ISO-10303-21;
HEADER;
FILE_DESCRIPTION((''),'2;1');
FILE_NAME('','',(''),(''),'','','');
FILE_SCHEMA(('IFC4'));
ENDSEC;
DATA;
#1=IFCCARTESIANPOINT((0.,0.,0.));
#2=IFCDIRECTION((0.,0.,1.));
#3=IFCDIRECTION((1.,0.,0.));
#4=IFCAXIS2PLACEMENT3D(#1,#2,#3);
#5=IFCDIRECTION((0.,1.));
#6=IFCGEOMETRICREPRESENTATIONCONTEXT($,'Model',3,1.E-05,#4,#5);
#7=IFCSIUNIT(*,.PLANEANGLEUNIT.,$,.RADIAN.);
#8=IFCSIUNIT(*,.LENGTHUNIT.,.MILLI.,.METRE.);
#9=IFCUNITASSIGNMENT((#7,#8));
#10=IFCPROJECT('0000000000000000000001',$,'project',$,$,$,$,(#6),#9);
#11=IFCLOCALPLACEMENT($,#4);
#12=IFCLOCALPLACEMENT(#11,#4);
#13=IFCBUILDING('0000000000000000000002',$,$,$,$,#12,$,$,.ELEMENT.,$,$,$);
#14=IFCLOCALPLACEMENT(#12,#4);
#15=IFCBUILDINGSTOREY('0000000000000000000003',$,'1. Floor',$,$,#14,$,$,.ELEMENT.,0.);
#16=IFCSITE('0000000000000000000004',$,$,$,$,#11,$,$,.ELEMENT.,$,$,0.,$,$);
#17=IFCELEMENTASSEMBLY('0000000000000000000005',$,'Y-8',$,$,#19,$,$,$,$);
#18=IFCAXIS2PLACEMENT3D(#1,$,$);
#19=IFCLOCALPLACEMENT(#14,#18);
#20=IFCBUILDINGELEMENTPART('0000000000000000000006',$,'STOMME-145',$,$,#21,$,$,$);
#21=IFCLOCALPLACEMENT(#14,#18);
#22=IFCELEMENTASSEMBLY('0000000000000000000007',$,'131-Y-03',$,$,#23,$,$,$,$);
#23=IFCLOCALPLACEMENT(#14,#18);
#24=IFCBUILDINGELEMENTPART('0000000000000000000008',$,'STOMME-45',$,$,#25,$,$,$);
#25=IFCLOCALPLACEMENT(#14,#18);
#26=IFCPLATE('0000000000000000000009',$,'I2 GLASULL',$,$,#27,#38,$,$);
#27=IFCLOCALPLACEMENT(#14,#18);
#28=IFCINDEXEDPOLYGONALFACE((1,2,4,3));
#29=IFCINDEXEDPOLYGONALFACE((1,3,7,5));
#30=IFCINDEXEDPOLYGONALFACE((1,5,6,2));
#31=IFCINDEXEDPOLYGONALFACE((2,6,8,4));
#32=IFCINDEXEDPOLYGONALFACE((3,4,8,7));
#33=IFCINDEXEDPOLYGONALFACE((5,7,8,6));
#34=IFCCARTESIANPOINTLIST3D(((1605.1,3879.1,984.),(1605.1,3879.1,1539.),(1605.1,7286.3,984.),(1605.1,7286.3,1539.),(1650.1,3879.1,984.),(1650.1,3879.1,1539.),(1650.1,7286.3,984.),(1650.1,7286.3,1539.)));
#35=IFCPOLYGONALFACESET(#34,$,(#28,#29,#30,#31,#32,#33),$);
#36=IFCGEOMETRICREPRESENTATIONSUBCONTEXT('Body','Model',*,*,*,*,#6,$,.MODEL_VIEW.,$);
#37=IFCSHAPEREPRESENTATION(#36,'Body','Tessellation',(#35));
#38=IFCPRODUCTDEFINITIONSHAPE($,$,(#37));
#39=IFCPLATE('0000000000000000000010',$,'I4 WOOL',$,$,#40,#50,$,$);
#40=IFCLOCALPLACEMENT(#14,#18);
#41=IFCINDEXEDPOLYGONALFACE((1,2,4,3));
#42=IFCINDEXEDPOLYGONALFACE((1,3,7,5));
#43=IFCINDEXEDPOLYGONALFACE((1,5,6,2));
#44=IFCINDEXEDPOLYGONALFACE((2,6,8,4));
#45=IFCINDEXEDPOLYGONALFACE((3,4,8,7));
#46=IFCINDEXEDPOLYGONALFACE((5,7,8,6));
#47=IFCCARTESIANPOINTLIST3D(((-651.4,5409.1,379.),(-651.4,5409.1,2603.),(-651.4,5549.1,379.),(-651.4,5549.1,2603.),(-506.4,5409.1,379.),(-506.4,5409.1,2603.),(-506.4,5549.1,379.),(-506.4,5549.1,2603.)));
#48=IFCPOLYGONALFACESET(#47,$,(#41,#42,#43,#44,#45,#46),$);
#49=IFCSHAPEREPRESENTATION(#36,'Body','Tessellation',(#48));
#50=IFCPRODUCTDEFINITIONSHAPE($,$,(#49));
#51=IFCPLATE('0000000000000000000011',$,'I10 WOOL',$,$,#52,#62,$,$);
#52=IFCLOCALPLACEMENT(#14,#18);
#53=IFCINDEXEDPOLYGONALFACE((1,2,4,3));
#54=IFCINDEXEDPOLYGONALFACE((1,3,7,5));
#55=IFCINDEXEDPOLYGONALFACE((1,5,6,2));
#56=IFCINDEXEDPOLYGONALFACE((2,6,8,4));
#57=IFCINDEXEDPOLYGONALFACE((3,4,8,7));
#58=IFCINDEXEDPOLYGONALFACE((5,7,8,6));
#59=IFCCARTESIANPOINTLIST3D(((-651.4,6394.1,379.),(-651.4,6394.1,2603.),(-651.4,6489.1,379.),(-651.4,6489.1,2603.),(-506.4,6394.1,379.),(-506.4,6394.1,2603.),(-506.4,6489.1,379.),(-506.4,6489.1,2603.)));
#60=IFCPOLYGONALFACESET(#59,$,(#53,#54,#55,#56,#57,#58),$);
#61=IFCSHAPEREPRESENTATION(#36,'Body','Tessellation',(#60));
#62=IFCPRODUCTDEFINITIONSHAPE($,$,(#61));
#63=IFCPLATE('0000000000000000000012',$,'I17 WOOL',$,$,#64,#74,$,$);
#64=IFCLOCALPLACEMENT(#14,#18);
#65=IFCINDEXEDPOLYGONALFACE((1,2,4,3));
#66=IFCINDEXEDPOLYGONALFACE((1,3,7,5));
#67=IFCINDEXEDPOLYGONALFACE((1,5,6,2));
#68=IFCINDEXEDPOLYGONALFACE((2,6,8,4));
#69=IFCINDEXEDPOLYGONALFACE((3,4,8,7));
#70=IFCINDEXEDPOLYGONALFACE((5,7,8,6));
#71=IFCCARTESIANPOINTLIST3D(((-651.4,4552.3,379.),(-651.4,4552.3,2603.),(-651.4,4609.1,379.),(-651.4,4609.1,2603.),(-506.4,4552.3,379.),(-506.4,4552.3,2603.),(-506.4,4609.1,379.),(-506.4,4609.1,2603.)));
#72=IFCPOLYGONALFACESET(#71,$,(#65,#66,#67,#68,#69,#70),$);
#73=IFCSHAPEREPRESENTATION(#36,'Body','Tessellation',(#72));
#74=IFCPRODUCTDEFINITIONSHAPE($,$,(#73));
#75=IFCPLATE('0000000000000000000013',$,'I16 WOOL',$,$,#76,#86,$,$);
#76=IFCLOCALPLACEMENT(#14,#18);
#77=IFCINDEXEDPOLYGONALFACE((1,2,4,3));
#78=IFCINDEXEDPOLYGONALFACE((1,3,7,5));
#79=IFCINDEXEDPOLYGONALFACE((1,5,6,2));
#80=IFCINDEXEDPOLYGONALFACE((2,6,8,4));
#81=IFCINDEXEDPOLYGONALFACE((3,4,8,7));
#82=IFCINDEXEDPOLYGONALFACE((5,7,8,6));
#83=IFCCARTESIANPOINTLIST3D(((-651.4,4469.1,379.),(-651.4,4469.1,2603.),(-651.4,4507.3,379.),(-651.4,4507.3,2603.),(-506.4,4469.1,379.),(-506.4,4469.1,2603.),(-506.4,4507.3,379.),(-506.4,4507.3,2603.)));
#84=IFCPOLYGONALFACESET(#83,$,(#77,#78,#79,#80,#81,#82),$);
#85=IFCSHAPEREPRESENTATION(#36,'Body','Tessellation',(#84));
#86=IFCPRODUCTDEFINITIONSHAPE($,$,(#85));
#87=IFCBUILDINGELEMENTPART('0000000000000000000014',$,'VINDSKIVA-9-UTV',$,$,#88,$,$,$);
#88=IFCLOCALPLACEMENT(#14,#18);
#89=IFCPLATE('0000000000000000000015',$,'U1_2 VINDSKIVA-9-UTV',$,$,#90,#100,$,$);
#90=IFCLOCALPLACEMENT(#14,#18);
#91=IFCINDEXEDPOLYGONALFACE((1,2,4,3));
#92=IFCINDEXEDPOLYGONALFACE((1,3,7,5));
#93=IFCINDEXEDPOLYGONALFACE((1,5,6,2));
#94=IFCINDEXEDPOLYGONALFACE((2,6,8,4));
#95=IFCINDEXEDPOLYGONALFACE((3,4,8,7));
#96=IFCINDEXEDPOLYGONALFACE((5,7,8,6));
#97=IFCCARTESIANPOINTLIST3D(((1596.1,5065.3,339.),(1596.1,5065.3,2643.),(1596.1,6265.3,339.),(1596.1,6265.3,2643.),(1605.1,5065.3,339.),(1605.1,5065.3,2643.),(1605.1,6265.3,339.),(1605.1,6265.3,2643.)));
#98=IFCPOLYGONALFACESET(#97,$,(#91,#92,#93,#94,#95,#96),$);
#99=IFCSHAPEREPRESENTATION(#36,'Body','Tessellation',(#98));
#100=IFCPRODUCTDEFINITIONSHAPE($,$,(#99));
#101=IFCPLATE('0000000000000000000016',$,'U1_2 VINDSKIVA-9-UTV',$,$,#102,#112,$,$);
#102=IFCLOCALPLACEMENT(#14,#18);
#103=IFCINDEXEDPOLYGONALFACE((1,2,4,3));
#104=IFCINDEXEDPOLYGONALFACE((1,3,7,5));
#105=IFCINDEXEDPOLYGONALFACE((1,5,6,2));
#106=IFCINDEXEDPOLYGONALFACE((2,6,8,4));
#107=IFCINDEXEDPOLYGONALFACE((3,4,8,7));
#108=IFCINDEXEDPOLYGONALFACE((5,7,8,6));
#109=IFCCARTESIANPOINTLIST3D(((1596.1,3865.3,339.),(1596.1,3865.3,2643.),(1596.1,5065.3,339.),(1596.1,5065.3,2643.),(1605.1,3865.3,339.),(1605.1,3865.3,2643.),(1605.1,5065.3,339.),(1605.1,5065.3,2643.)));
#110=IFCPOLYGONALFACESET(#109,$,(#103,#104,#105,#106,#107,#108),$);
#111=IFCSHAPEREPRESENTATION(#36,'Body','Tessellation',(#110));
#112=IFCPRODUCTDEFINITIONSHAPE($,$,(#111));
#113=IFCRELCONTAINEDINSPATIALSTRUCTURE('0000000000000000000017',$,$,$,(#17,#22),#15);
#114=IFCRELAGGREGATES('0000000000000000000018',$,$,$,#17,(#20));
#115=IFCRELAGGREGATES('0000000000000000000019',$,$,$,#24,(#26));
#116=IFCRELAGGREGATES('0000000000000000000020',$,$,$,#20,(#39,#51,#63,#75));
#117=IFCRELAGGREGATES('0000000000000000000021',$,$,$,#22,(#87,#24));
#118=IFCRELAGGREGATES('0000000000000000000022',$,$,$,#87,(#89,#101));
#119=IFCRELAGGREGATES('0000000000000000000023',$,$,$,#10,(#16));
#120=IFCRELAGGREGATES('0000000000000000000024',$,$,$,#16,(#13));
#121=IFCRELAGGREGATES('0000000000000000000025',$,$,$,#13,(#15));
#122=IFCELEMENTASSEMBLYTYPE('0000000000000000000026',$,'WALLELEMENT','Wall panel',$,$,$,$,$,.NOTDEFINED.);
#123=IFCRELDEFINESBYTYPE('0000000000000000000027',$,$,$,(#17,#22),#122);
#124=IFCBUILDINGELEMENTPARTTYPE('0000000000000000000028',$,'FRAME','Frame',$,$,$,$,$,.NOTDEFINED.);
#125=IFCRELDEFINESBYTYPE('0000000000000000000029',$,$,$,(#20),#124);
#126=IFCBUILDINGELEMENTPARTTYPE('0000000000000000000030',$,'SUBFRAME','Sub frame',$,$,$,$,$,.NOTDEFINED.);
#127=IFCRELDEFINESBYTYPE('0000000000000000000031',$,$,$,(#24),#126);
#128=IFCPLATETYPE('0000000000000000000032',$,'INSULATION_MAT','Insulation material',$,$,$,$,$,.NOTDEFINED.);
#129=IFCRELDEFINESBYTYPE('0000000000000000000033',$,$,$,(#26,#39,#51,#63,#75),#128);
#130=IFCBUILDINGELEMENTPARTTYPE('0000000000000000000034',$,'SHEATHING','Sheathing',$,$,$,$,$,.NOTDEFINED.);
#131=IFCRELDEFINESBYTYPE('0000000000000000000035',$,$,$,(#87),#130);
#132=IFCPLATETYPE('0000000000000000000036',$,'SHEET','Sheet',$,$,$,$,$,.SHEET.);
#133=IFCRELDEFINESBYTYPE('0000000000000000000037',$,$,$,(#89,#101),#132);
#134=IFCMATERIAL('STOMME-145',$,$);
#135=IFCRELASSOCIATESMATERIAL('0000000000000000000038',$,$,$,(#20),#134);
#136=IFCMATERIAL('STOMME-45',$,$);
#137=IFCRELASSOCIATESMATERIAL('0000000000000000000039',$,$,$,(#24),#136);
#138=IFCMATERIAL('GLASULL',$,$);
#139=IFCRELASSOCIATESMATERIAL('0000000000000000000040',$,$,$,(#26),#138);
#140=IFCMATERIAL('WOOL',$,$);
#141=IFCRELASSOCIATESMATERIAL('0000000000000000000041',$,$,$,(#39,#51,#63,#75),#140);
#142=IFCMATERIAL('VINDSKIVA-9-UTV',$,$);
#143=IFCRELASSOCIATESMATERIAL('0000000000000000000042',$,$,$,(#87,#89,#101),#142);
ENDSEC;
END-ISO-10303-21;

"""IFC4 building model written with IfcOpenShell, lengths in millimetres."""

from ifc_helpers import new_model, si_unit, direction, frame, origin_with_axes, origin_2d_with_axis, place, context, subcontext, project, spatial, rectangle, extrude, material, type_object, element, aggregate, save


model = new_model("IFC4")

# Units and contexts
model_context = context("Model", 3, precision=1e-05, world=origin_with_axes(), true_north=direction((0.0, 1.0)))
body_context = subcontext(model_context, "Body", "Model", "MODEL_VIEW")
ifc_project = project(units=[si_unit("PLANEANGLEUNIT", "RADIAN"), si_unit("LENGTHUNIT", "METRE", prefix="MILLI")], contexts=[model_context])

# Site, building, storey
site_placement = place(None, origin_with_axes())
site = spatial("IfcSite", under=ifc_project, at=site_placement, CompositionType="ELEMENT", RefElevation=0.0)
building_placement = place(site_placement, origin_with_axes())
building = spatial("IfcBuilding", under=site, at=building_placement, CompositionType="ELEMENT")
storey_placement = place(building_placement, origin_with_axes())
storey = spatial("IfcBuildingStorey", under=building, at=storey_placement, Name="1. Floor", CompositionType="ELEMENT", Elevation=0.0)

# Element assembly, building element part
element_assembly_type = type_object("IfcElementAssemblyType", Name="WALLELEMENT", Description="Wall panel", PredefinedType="NOTDEFINED")
assembly_1_placement = place(storey_placement, origin_with_axes())
assembly_1 = element("IfcElementAssembly", 1, at=assembly_1_placement, inside=storey, type_object=element_assembly_type, Name="Y-8")
ifc_material_1 = material(Name="STOMME-145")
building_element_part_type_1 = type_object("IfcBuildingElementPartType", Name="FRAME", Description="Frame", PredefinedType="NOTDEFINED")
building_element_part_1_placement = place(storey_placement, origin_with_axes())
building_element_part_1 = element("IfcBuildingElementPart", 2, at=building_element_part_1_placement, type_object=building_element_part_type_1, material=ifc_material_1, Name="STOMME-145")

# Element assembly, building element part
assembly_2_placement = place(storey_placement, origin_with_axes())
assembly_2 = element("IfcElementAssembly", 3, at=assembly_2_placement, inside=storey, type_object=element_assembly_type, Name="131-Y-03")
ifc_material_2 = material(Name="STOMME-45")
building_element_part_type_2 = type_object("IfcBuildingElementPartType", Name="SUBFRAME", Description="Sub frame", PredefinedType="NOTDEFINED")
building_element_part_2_placement = place(storey_placement, origin_with_axes())
building_element_part_2 = element("IfcBuildingElementPart", 4, at=building_element_part_2_placement, type_object=building_element_part_type_2, material=ifc_material_2, Name="STOMME-45")

aggregate(assembly_1, [building_element_part_1])

# Plates
ifc_material_3 = material(Name="GLASULL")
plate_type_1 = type_object("IfcPlateType", Name="INSULATION_MAT", Description="Insulation material", PredefinedType="NOTDEFINED")
plate_1_placement = place(storey_placement, frame((1605.1, 5582.7, 1261.5), z_axis=(-1.0, 0.0, 0.0), x_axis=(0.0, -1.0, 0.0)))
plate_1 = element("IfcPlate", 5, at=plate_1_placement, type_object=plate_type_1, material=ifc_material_3, Name="I2 GLASULL", context=body_context, shape_type="SweptSolid", body=[
    extrude(rectangle(XDim=45.0, YDim=3407.2, at=origin_2d_with_axis()), frame((0.0, -277.5, -22.5), z_axis=(0.0, 1.0, 0.0), x_axis=(0.0, 0.0, 1.0)), (0.0, 0.0, 1.0), 555.0),
])
aggregate(building_element_part_2, [plate_1])
ifc_material_4 = material(Name="WOOL")
plate_2_placement = place(storey_placement, frame((-651.4, 5479.1, 1491.0), z_axis=(-1.0, 0.0, 0.0), x_axis=(0.0, -1.0, 0.0)))
plate_2 = element("IfcPlate", 6, at=plate_2_placement, type_object=plate_type_1, material=ifc_material_4, Name="I4 WOOL", context=body_context, shape_type="SweptSolid", body=[
    extrude(rectangle(XDim=145.0, YDim=140.0, at=origin_2d_with_axis()), frame((0.0, -1112.0, -72.5), z_axis=(0.0, 1.0, 0.0), x_axis=(0.0, 0.0, 1.0)), (0.0, 0.0, 1.0), 2224.0),
])
plate_3_placement = place(storey_placement, frame((-651.4, 6441.6, 1491.0), z_axis=(-1.0, 0.0, 0.0), x_axis=(0.0, -1.0, 0.0)))
plate_3 = element("IfcPlate", 7, at=plate_3_placement, type_object=plate_type_1, material=ifc_material_4, Name="I10 WOOL", context=body_context, shape_type="SweptSolid", body=[
    extrude(rectangle(XDim=145.0, YDim=95.0, at=origin_2d_with_axis()), frame((0.0, -1112.0, -72.5), z_axis=(0.0, 1.0, 0.0), x_axis=(0.0, 0.0, 1.0)), (0.0, 0.0, 1.0), 2224.0),
])
plate_4_placement = place(storey_placement, frame((-651.4, 4580.7, 1491.0), z_axis=(-1.0, 0.0, 0.0), x_axis=(0.0, -1.0, 0.0)))
plate_4 = element("IfcPlate", 8, at=plate_4_placement, type_object=plate_type_1, material=ifc_material_4, Name="I17 WOOL", context=body_context, shape_type="SweptSolid", body=[
    extrude(rectangle(XDim=145.0, YDim=56.8, at=origin_2d_with_axis()), frame((0.0, -1112.0, -72.5), z_axis=(0.0, 1.0, 0.0), x_axis=(0.0, 0.0, 1.0)), (0.0, 0.0, 1.0), 2224.0),
])
plate_5_placement = place(storey_placement, frame((-651.4, 4488.2, 1491.0), z_axis=(-1.0, 0.0, 0.0), x_axis=(0.0, -1.0, 0.0)))
plate_5 = element("IfcPlate", 9, at=plate_5_placement, type_object=plate_type_1, material=ifc_material_4, Name="I16 WOOL", context=body_context, shape_type="SweptSolid", body=[
    extrude(rectangle(XDim=145.0, YDim=38.2, at=origin_2d_with_axis()), frame((0.0, -1112.0, -72.5), z_axis=(0.0, 1.0, 0.0), x_axis=(0.0, 0.0, 1.0)), (0.0, 0.0, 1.0), 2224.0),
])
aggregate(building_element_part_1, [plate_2, plate_3, plate_4, plate_5])

# Building element part
ifc_material_5 = material(Name="VINDSKIVA-9-UTV")
building_element_part_type_3 = type_object("IfcBuildingElementPartType", Name="SHEATHING", Description="Sheathing", PredefinedType="NOTDEFINED")
building_element_part_3_placement = place(storey_placement, origin_with_axes())
building_element_part_3 = element("IfcBuildingElementPart", 10, at=building_element_part_3_placement, type_object=building_element_part_type_3, material=ifc_material_5, Name="VINDSKIVA-9-UTV")
aggregate(assembly_2, [building_element_part_3, building_element_part_2])

# Plates
plate_type_2 = type_object("IfcPlateType", Name="SHEET", Description="Sheet", PredefinedType="SHEET")
plate_6_placement = place(storey_placement, frame((1596.1, 5665.3, 2339.0), z_axis=(-1.0, 0.0, 0.0), x_axis=(0.0, 1.0, 0.0)))
plate_6 = element("IfcPlate", 11, at=plate_6_placement, type_object=plate_type_2, material=ifc_material_5, Name="U1_2 VINDSKIVA-9-UTV", context=body_context, shape_type="SweptSolid", body=[
    extrude(rectangle(XDim=9.0, YDim=1200.0, at=origin_2d_with_axis()), frame((0.0, -304.0, -4.5), z_axis=(0.0, 1.0, 0.0), x_axis=(0.0, 0.0, 1.0)), (0.0, 0.0, 1.0), 2304.0),
])
plate_7_placement = place(storey_placement, frame((1596.1, 4465.3, 2339.0), z_axis=(-1.0, 0.0, 0.0), x_axis=(0.0, 1.0, 0.0)))
plate_7 = element("IfcPlate", 12, at=plate_7_placement, type_object=plate_type_2, material=ifc_material_5, Name="U1_2 VINDSKIVA-9-UTV", context=body_context, shape_type="SweptSolid", body=[
    extrude(rectangle(XDim=9.0, YDim=1200.0, at=origin_2d_with_axis()), frame((0.0, -304.0, -4.5), z_axis=(0.0, 1.0, 0.0), x_axis=(0.0, 0.0, 1.0)), (0.0, 0.0, 1.0), 2304.0),
])
aggregate(building_element_part_3, [plate_6, plate_7])

save(model, "model.ifc")
